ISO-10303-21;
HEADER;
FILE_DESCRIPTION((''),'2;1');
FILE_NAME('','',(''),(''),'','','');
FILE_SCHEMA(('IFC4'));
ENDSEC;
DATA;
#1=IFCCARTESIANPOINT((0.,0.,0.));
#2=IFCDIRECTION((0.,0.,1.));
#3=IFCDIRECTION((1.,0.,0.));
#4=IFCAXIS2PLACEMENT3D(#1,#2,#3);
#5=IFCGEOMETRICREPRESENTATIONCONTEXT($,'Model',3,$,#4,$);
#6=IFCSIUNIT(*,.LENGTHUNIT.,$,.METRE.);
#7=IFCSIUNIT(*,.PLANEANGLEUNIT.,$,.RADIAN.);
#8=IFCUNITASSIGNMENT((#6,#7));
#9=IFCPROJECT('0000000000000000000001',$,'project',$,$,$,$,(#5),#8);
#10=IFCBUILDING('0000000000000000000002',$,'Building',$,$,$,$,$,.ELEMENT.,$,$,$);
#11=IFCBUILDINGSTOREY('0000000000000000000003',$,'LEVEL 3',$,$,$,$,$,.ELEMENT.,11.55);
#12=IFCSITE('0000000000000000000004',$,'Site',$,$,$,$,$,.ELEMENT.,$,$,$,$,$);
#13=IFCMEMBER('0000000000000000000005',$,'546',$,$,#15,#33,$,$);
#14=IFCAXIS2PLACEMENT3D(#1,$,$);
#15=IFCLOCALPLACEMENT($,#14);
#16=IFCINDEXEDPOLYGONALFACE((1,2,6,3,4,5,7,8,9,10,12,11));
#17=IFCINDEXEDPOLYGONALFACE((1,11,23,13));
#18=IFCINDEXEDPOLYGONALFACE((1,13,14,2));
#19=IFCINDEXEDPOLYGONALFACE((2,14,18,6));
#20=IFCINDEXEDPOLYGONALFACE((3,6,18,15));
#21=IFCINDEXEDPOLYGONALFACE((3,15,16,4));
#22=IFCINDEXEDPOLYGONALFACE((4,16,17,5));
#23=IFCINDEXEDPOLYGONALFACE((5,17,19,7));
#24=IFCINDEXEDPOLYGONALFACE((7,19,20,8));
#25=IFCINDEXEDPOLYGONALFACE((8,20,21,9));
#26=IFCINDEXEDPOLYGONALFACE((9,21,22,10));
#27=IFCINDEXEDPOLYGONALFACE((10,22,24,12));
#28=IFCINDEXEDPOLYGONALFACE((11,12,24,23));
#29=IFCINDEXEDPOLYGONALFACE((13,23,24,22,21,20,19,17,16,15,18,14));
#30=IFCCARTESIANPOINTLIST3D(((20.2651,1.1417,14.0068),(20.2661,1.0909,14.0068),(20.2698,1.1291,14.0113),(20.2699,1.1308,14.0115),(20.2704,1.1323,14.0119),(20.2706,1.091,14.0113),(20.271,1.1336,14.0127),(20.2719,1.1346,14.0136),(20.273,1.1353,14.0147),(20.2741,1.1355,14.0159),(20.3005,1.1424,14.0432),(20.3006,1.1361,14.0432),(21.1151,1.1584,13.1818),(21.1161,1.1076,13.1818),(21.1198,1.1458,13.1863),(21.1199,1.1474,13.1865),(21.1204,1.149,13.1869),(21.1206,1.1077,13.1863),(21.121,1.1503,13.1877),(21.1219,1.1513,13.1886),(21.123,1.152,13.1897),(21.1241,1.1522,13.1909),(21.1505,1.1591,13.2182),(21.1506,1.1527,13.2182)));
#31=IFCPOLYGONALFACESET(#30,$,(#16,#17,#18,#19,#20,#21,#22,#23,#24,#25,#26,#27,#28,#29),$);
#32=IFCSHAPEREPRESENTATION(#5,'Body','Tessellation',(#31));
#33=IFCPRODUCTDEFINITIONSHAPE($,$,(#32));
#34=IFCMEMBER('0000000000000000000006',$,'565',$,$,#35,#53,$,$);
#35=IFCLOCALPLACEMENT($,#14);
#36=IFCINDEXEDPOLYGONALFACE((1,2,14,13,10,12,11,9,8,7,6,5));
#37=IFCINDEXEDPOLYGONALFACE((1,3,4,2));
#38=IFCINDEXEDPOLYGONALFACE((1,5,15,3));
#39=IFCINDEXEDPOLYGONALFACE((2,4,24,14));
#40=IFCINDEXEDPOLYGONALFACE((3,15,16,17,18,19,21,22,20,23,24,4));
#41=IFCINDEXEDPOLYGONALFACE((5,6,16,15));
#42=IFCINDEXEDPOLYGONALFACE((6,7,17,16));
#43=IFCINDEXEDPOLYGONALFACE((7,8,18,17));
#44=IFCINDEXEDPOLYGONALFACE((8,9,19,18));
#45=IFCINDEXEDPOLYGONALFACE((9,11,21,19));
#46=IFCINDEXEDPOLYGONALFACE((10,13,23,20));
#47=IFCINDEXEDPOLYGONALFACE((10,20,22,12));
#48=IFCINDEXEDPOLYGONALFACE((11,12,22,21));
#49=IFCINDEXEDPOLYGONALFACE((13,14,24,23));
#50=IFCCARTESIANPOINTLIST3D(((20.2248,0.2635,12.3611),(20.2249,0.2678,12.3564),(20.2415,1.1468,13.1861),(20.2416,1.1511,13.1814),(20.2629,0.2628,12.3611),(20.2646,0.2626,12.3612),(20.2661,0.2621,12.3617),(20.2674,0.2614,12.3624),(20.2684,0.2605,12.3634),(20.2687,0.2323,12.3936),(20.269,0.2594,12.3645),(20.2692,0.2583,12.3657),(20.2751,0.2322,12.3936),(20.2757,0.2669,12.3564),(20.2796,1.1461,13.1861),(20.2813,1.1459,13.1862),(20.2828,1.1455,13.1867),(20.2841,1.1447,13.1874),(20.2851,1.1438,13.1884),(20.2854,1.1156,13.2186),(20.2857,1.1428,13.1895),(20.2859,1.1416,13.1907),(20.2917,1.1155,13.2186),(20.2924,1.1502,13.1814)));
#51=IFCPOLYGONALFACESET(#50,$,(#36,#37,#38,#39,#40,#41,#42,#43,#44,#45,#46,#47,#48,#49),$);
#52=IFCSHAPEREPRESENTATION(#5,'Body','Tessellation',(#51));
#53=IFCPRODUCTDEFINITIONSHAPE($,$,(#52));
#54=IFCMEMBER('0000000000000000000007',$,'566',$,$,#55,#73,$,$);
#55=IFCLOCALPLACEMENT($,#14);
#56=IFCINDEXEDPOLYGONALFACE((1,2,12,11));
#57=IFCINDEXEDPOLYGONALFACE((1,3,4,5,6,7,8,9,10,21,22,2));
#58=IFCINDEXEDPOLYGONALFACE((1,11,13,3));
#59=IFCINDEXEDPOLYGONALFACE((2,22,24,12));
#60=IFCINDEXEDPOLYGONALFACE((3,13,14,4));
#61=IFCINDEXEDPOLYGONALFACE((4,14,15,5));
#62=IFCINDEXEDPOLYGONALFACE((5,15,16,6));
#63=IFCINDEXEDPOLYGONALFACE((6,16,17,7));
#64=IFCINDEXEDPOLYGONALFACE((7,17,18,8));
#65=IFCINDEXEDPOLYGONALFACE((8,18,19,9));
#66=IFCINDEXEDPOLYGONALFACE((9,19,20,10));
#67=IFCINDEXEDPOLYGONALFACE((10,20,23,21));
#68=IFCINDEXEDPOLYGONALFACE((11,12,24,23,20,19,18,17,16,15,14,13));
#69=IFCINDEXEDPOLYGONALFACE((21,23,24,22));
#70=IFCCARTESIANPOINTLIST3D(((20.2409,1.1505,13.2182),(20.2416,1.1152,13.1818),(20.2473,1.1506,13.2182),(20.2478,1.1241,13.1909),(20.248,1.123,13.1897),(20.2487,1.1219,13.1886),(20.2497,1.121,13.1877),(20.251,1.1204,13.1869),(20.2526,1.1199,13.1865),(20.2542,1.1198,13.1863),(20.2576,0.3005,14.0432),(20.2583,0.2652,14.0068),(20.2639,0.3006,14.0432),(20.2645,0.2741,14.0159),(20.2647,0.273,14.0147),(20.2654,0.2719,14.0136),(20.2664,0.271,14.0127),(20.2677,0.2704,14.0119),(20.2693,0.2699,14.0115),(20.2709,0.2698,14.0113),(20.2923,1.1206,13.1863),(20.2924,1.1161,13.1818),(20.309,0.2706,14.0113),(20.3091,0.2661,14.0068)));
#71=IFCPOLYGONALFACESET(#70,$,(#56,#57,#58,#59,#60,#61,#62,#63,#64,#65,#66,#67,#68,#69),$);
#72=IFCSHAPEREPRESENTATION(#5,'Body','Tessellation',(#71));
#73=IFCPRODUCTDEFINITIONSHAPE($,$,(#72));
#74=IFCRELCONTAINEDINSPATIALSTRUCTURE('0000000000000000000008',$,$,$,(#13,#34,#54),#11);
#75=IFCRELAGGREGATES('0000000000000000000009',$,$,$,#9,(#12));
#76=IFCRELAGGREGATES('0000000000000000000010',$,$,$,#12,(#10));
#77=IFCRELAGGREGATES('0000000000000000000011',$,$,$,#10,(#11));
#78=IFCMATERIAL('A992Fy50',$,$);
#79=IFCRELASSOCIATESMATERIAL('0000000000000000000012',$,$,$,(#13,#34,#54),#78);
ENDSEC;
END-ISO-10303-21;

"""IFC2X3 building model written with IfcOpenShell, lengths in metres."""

from ifc_helpers import new_model, si_unit, frame, origin_with_axes, origin_2d_with_axis, place, context, project, spatial, l_section, extrude, material, element, save


model = new_model("IFC2X3")

# Units and contexts
model_context = context("Model", 3, world=origin_with_axes())
ifc_project = project(units=[si_unit("LENGTHUNIT", "METRE"), si_unit("PLANEANGLEUNIT", "RADIAN")], contexts=[model_context])

# Site, building, storey
site = spatial("IfcSite", under=ifc_project, Name="Site", CompositionType="ELEMENT")
building = spatial("IfcBuilding", under=site, Name="Building", CompositionType="ELEMENT")
storey = spatial("IfcBuildingStorey", under=building, Name="LEVEL 3", CompositionType="ELEMENT", Elevation=11.55)

# Shared definitions
ifc_material = material(Name="A992Fy50")

# Members
member_1_placement = place(None, frame((21.1333, 1.1333, 13.2), z_axis=(-0.71751, -0.014069, 0.696406), x_axis=(0.019604, -0.999808, 0.0)))
element("IfcMember", 1, at=member_1_placement, inside=storey, material=ifc_material, Name="546", context=model_context, shape_type="SweptSolid", body=[
    extrude(l_section(Depth=0.0508, Width=0.0508, Thickness=0.0063, FilletRadius=0.0063, at=origin_2d_with_axis()), origin_with_axes(), (0.0, 0.0, 1.0), 1.1847),
])
member_2_placement = place(None, frame((20.25, 0.25, 12.375), z_axis=(0.013788, 0.730756, 0.682499), x_axis=(-0.999822, 0.018865, 0.0)))
element("IfcMember", 2, at=member_2_placement, inside=storey, material=ifc_material, Name="565", context=model_context, shape_type="SweptSolid", body=[
    extrude(l_section(Depth=0.0508, Width=0.0508, Thickness=0.0063, FilletRadius=0.0063, at=origin_2d_with_axis()), origin_with_axes(), (0.0, 0.0, 1.0), 1.2088),
])
member_3_placement = place(None, frame((20.2667, 1.1333, 13.2), z_axis=(0.014069, -0.71751, 0.696406), x_axis=(0.999808, 0.019604, 0.0)))
element("IfcMember", 3, at=member_3_placement, inside=storey, material=ifc_material, Name="566", context=model_context, shape_type="SweptSolid", body=[
    extrude(l_section(Depth=0.0508, Width=0.0508, Thickness=0.0063, FilletRadius=0.0063, at=origin_2d_with_axis()), origin_with_axes(), (0.0, 0.0, 1.0), 1.1847),
])

save(model, "model.ifc")
